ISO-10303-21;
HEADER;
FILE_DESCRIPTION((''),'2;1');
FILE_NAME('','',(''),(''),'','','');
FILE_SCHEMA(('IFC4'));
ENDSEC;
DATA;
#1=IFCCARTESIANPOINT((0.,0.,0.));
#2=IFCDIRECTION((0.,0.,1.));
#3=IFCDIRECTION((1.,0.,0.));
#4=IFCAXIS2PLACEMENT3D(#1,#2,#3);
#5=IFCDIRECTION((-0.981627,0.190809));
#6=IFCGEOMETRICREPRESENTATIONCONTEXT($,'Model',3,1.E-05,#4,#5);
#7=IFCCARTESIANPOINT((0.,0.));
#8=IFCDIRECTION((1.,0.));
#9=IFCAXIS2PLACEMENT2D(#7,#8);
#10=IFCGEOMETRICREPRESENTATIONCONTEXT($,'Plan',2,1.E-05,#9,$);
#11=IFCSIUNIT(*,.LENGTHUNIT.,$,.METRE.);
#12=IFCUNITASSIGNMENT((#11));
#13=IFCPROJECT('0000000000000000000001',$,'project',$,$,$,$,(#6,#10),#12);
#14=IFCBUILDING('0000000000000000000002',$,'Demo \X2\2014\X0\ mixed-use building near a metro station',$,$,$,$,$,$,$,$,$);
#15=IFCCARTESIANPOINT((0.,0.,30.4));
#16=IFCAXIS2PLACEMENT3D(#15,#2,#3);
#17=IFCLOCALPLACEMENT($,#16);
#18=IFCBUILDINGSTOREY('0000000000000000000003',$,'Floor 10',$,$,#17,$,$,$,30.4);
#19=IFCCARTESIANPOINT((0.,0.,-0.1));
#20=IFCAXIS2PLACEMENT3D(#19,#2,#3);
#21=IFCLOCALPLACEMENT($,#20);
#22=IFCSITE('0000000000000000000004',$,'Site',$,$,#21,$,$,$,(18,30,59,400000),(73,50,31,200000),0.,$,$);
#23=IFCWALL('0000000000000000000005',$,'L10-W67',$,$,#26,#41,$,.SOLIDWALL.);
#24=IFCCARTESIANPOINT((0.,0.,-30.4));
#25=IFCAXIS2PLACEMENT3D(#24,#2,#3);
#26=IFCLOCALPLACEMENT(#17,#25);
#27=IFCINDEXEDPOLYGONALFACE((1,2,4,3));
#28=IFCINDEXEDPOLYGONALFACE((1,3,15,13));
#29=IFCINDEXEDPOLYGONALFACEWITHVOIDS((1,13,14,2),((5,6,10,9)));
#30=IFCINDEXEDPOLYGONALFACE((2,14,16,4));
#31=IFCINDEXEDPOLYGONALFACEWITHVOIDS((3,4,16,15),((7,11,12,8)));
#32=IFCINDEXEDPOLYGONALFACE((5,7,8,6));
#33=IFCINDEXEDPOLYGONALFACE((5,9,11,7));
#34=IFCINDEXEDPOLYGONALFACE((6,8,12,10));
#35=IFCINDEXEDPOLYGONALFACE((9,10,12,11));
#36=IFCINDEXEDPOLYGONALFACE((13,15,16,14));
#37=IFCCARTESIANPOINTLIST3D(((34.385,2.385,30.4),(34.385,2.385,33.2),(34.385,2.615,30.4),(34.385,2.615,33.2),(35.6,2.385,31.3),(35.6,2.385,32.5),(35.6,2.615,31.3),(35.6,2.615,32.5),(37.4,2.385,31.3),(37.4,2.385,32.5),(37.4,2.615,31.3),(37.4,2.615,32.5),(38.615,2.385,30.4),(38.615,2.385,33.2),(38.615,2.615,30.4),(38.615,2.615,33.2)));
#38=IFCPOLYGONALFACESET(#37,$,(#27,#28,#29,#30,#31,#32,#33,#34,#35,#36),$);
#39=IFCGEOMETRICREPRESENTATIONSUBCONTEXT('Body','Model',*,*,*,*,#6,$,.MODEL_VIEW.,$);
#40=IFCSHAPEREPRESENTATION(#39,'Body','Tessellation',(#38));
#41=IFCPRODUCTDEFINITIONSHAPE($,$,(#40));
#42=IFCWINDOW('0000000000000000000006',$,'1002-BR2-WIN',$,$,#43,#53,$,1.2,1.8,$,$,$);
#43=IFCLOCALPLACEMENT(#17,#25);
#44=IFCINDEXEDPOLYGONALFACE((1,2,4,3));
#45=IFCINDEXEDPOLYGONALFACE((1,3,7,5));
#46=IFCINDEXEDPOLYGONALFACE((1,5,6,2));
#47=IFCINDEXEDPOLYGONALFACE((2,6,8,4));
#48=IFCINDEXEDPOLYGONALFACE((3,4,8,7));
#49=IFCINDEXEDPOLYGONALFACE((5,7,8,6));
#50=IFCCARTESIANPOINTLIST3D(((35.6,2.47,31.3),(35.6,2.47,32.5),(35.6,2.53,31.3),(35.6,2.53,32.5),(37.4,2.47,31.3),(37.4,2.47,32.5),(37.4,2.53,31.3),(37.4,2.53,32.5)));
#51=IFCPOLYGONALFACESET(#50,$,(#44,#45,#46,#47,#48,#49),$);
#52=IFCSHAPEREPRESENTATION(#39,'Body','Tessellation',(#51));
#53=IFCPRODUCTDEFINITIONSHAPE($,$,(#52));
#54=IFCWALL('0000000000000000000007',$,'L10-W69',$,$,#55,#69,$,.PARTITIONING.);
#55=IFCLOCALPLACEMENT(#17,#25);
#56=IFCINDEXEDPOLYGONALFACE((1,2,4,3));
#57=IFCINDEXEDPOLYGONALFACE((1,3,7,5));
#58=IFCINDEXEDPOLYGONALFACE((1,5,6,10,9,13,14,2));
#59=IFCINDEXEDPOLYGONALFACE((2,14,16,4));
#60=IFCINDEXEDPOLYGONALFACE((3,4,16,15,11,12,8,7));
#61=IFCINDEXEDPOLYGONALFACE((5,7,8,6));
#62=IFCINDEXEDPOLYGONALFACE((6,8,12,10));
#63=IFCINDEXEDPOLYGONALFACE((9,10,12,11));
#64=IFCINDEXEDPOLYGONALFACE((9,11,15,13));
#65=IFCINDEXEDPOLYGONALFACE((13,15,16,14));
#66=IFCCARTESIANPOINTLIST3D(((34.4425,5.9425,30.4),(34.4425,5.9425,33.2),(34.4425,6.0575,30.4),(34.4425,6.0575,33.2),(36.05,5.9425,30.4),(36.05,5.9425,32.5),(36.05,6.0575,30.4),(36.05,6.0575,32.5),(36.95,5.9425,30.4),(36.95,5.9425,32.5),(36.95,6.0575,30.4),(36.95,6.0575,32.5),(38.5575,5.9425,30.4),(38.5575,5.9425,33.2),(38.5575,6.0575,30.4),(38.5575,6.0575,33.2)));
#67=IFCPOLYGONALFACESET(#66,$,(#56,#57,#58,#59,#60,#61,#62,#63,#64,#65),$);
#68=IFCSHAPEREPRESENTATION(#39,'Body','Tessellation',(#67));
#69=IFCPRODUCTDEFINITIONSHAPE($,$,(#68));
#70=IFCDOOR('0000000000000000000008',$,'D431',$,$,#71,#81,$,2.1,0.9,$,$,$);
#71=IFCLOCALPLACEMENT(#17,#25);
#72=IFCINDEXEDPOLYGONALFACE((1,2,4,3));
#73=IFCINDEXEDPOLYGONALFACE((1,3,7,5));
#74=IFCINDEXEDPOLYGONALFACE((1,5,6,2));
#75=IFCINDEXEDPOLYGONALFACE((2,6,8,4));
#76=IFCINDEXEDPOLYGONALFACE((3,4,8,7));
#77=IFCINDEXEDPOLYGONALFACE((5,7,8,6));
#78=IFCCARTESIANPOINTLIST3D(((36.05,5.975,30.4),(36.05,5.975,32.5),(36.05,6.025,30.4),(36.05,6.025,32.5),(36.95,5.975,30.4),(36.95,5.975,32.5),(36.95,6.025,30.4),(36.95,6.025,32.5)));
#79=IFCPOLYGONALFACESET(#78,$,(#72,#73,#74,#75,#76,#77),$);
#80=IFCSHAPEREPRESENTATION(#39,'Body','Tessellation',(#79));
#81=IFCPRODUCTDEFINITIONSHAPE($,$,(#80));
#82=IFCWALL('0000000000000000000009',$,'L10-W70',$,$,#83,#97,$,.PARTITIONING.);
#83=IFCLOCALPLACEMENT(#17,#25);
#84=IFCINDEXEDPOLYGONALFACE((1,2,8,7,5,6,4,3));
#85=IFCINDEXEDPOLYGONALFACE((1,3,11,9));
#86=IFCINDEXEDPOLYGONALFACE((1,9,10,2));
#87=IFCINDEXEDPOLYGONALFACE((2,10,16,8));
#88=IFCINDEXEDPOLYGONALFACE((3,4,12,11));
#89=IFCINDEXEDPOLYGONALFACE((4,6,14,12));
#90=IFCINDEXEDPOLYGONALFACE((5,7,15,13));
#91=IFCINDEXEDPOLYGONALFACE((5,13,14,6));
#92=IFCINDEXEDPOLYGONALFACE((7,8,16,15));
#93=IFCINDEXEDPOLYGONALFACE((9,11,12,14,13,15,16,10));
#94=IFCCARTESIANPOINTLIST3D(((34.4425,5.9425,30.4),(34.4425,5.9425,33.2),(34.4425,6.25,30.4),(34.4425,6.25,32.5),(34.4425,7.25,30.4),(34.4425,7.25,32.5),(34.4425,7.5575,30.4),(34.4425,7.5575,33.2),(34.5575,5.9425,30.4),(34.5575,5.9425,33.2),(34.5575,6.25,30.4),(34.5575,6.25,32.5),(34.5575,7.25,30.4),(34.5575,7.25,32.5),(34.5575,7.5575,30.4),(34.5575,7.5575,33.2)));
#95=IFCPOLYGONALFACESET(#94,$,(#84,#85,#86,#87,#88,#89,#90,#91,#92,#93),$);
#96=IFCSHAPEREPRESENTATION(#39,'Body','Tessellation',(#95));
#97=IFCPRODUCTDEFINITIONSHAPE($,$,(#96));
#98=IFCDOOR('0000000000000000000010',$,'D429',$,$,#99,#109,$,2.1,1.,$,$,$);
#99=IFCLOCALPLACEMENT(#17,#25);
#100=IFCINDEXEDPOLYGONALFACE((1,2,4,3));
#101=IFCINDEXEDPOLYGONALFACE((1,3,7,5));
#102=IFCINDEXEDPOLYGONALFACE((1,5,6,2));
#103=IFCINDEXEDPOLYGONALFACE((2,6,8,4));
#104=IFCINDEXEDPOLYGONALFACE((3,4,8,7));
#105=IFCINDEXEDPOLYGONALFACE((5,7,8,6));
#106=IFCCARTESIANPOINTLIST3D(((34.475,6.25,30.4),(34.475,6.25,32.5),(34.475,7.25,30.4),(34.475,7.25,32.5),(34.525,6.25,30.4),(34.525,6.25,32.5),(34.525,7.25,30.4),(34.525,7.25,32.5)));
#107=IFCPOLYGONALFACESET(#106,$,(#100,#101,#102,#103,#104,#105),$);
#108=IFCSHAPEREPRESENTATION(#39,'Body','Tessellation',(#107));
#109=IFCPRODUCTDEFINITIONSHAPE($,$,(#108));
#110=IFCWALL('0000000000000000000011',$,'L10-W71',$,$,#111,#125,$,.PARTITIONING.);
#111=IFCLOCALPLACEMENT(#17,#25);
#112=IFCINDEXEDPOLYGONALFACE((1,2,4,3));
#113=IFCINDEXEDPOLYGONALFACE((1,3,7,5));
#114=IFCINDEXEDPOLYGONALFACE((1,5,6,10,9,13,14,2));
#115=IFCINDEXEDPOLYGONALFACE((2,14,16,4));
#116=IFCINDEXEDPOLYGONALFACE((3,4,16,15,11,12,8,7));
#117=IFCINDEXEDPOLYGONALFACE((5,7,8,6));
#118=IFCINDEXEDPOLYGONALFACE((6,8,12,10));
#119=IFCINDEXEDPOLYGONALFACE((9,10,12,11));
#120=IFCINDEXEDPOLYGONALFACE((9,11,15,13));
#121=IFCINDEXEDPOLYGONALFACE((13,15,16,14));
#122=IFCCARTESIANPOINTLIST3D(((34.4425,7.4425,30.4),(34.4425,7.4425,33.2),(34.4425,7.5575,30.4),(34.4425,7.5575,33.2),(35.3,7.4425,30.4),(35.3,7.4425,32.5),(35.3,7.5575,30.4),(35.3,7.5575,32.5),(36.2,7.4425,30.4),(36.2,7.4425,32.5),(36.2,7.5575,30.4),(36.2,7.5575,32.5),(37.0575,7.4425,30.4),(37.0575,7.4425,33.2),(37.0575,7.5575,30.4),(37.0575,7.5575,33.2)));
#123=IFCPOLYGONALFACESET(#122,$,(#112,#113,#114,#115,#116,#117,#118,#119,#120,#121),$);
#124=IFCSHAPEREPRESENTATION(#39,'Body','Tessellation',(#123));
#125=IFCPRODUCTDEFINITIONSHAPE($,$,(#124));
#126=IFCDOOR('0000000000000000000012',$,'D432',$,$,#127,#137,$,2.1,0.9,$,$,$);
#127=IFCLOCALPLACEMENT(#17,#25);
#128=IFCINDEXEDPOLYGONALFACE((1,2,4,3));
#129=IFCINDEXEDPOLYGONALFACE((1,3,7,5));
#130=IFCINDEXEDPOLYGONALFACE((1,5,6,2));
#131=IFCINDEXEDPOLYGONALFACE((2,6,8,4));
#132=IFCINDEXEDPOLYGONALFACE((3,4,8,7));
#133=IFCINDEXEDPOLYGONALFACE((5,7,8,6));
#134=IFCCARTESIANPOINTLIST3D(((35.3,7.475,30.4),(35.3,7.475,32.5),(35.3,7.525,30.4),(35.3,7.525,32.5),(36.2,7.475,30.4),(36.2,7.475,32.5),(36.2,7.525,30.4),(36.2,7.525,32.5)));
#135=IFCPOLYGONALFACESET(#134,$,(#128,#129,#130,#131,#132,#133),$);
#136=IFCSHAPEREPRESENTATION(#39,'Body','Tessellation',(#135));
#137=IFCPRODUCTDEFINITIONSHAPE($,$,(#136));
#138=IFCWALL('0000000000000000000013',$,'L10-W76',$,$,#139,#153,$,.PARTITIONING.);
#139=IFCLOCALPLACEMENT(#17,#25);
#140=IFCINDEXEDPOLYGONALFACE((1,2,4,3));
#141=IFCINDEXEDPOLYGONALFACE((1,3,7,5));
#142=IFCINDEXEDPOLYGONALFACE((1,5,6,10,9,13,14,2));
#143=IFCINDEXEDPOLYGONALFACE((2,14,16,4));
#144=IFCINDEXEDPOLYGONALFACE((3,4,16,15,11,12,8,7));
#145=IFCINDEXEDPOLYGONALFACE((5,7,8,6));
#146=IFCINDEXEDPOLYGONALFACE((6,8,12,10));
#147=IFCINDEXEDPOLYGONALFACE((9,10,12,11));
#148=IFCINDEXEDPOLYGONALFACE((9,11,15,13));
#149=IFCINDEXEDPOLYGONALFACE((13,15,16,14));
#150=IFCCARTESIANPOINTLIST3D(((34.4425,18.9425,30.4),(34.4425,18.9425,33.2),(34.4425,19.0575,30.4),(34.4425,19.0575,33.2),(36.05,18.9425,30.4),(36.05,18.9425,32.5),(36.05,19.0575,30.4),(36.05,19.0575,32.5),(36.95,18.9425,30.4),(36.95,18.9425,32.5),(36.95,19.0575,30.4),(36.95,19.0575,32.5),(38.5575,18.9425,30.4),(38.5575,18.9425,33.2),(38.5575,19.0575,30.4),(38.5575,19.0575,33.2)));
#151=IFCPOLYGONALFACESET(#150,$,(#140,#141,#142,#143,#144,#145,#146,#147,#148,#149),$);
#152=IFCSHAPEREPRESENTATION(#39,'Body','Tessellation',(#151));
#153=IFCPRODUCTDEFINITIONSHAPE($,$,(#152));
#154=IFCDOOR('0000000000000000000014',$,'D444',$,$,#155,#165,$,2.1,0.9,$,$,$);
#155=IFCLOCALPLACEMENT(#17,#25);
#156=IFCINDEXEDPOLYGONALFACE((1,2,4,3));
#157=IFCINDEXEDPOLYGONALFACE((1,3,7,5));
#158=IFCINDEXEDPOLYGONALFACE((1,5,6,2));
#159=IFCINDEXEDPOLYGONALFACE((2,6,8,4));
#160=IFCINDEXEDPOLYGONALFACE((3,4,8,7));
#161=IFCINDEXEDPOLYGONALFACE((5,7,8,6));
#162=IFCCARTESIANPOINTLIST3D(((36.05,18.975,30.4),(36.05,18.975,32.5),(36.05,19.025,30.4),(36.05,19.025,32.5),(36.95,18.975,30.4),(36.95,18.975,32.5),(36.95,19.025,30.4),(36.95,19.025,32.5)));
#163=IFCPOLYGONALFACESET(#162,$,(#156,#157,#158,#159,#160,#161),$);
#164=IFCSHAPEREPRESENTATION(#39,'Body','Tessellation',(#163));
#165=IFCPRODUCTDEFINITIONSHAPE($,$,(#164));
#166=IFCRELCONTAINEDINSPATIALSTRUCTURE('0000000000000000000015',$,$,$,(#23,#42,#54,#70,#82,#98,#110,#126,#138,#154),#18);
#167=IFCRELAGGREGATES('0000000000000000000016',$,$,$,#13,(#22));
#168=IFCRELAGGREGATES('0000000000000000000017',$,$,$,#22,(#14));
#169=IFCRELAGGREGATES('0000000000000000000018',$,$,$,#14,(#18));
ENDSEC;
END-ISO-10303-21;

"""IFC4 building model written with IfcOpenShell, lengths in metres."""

from ifc_helpers import new_model, si_unit, direction, frame, origin_with_axes, origin_2d_with_axis, place, context, subcontext, project, spatial, line, indexed_curve, outline, extrude, element, fill, save


model = new_model("IFC4")

# Units and contexts
model_context = context("Model", 3, precision=1e-05, world=origin_with_axes(), true_north=direction((-0.981627, 0.190809)))
plan_context = context("Plan", 2, precision=1e-05, world=origin_2d_with_axis())
body_context = subcontext(model_context, "Body", "Model", "MODEL_VIEW")
ifc_project = project(units=[si_unit("LENGTHUNIT", "METRE")], contexts=[model_context, plan_context])

# Site, building, storey
site_placement = place(None, frame((0.0, 0.0, -0.1), z_axis=(0.0, 0.0, 1.0), x_axis=(1.0, 0.0, 0.0)))
site = spatial("IfcSite", under=ifc_project, at=site_placement, Name="Site", RefLatitude=(18, 30, 59, 400000), RefLongitude=(73, 50, 31, 200000), RefElevation=0.0)
building = spatial("IfcBuilding", under=site, Name="Demo — mixed-use building near a metro station")
storey_placement = place(None, frame((0.0, 0.0, 30.4), z_axis=(0.0, 0.0, 1.0), x_axis=(1.0, 0.0, 0.0)))
storey = spatial("IfcBuildingStorey", under=building, at=storey_placement, Name="Floor 10", Elevation=30.4)

# Wall, opening, window
wall_1_placement = place(storey_placement, frame((0.0, 0.0, -30.4), z_axis=(0.0, 0.0, 1.0), x_axis=(1.0, 0.0, 0.0)))
wall_1 = element("IfcWall", 1, at=wall_1_placement, inside=storey, Name="L10-W67", PredefinedType="SOLIDWALL", context=body_context, shape_type="SweptSolid", body=[
    extrude(outline(indexed_curve([(34.385, 2.615), (38.615, 2.615), (38.615, 2.385), (34.385, 2.385)], segments=[line(1, 2, 3, 4, 1)])), frame((0.0, 0.0, 30.4), z_axis=(0.0, 0.0, 1.0), x_axis=(1.0, 0.0, 0.0)), (0.0, 0.0, 1.0), 2.8),
])
opening_1_placement = place(wall_1_placement, origin_with_axes())
opening_1 = element("IfcOpeningElement", 2, at=opening_1_placement, cuts=wall_1, context=body_context, shape_type="SweptSolid", body=[
    extrude(outline(indexed_curve([(35.6, 2.665), (37.4, 2.665), (37.4, 2.335), (35.6, 2.335)], segments=[line(1, 2, 3, 4, 1)])), frame((0.0, 0.0, 31.3), z_axis=(0.0, 0.0, 1.0), x_axis=(1.0, 0.0, 0.0)), (0.0, 0.0, 1.0), 1.2),
])
window_placement = place(storey_placement, frame((0.0, 0.0, -30.4), z_axis=(0.0, 0.0, 1.0), x_axis=(1.0, 0.0, 0.0)))
window = element("IfcWindow", 3, at=window_placement, inside=storey, Name="1002-BR2-WIN", OverallHeight=1.2, OverallWidth=1.8, context=body_context, shape_type="SweptSolid", body=[
    extrude(outline(indexed_curve([(35.6, 2.53), (37.4, 2.53), (37.4, 2.47), (35.6, 2.47)], segments=[line(1, 2, 3, 4, 1)])), frame((0.0, 0.0, 31.3), z_axis=(0.0, 0.0, 1.0), x_axis=(1.0, 0.0, 0.0)), (0.0, 0.0, 1.0), 1.2),
])
fill(opening_1, window)

# Walls, openings, doors
wall_2_placement = place(storey_placement, frame((0.0, 0.0, -30.4), z_axis=(0.0, 0.0, 1.0), x_axis=(1.0, 0.0, 0.0)))
wall_2 = element("IfcWall", 4, at=wall_2_placement, inside=storey, Name="L10-W69", PredefinedType="PARTITIONING", context=body_context, shape_type="SweptSolid", body=[
    extrude(outline(indexed_curve([(38.5575, 5.9425), (34.4425, 5.9425), (34.4425, 6.0575), (38.5575, 6.0575)], segments=[line(1, 2, 3, 4, 1)])), frame((0.0, 0.0, 30.4), z_axis=(0.0, 0.0, 1.0), x_axis=(1.0, 0.0, 0.0)), (0.0, 0.0, 1.0), 2.8),
])
opening_2_placement = place(wall_2_placement, origin_with_axes())
opening_2 = element("IfcOpeningElement", 5, at=opening_2_placement, cuts=wall_2, context=body_context, shape_type="SweptSolid", body=[
    extrude(outline(indexed_curve([(36.95, 5.8925), (36.05, 5.8925), (36.05, 6.1075), (36.95, 6.1075)], segments=[line(1, 2, 3, 4, 1)])), frame((0.0, 0.0, 30.4), z_axis=(0.0, 0.0, 1.0), x_axis=(1.0, 0.0, 0.0)), (0.0, 0.0, 1.0), 2.1),
])
door_1_placement = place(storey_placement, frame((0.0, 0.0, -30.4), z_axis=(0.0, 0.0, 1.0), x_axis=(1.0, 0.0, 0.0)))
door_1 = element("IfcDoor", 6, at=door_1_placement, inside=storey, Name="D431", OverallHeight=2.1, OverallWidth=0.9, context=body_context, shape_type="SweptSolid", body=[
    extrude(outline(indexed_curve([(36.95, 5.975), (36.05, 5.975), (36.05, 6.025), (36.95, 6.025)], segments=[line(1, 2, 3, 4, 1)])), frame((0.0, 0.0, 30.4), z_axis=(0.0, 0.0, 1.0), x_axis=(1.0, 0.0, 0.0)), (0.0, 0.0, 1.0), 2.1),
])
fill(opening_2, door_1)
wall_3_placement = place(storey_placement, frame((0.0, 0.0, -30.4), z_axis=(0.0, 0.0, 1.0), x_axis=(1.0, 0.0, 0.0)))
wall_3 = element("IfcWall", 7, at=wall_3_placement, inside=storey, Name="L10-W70", PredefinedType="PARTITIONING", context=body_context, shape_type="SweptSolid", body=[
    extrude(outline(indexed_curve([(34.4425, 5.9425), (34.4425, 7.5575), (34.5575, 7.5575), (34.5575, 5.9425)], segments=[line(1, 2, 3, 4, 1)])), frame((0.0, 0.0, 30.4), z_axis=(0.0, 0.0, 1.0), x_axis=(1.0, 0.0, 0.0)), (0.0, 0.0, 1.0), 2.8),
])
opening_3_placement = place(wall_3_placement, origin_with_axes())
opening_3 = element("IfcOpeningElement", 8, at=opening_3_placement, cuts=wall_3, context=body_context, shape_type="SweptSolid", body=[
    extrude(outline(indexed_curve([(34.3925, 6.25), (34.3925, 7.25), (34.6075, 7.25), (34.6075, 6.25)], segments=[line(1, 2, 3, 4, 1)])), frame((0.0, 0.0, 30.4), z_axis=(0.0, 0.0, 1.0), x_axis=(1.0, 0.0, 0.0)), (0.0, 0.0, 1.0), 2.1),
])
door_2_placement = place(storey_placement, frame((0.0, 0.0, -30.4), z_axis=(0.0, 0.0, 1.0), x_axis=(1.0, 0.0, 0.0)))
door_2 = element("IfcDoor", 9, at=door_2_placement, inside=storey, Name="D429", OverallHeight=2.1, OverallWidth=1.0, context=body_context, shape_type="SweptSolid", body=[
    extrude(outline(indexed_curve([(34.475, 6.25), (34.475, 7.25), (34.525, 7.25), (34.525, 6.25)], segments=[line(1, 2, 3, 4, 1)])), frame((0.0, 0.0, 30.4), z_axis=(0.0, 0.0, 1.0), x_axis=(1.0, 0.0, 0.0)), (0.0, 0.0, 1.0), 2.1),
])
fill(opening_3, door_2)
wall_4_placement = place(storey_placement, frame((0.0, 0.0, -30.4), z_axis=(0.0, 0.0, 1.0), x_axis=(1.0, 0.0, 0.0)))
wall_4 = element("IfcWall", 10, at=wall_4_placement, inside=storey, Name="L10-W71", PredefinedType="PARTITIONING", context=body_context, shape_type="SweptSolid", body=[
    extrude(outline(indexed_curve([(37.0575, 7.4425), (34.4425, 7.4425), (34.4425, 7.5575), (37.0575, 7.5575)], segments=[line(1, 2, 3, 4, 1)])), frame((0.0, 0.0, 30.4), z_axis=(0.0, 0.0, 1.0), x_axis=(1.0, 0.0, 0.0)), (0.0, 0.0, 1.0), 2.8),
])
opening_4_placement = place(wall_4_placement, origin_with_axes())
opening_4 = element("IfcOpeningElement", 11, at=opening_4_placement, cuts=wall_4, context=body_context, shape_type="SweptSolid", body=[
    extrude(outline(indexed_curve([(36.2, 7.3925), (35.3, 7.3925), (35.3, 7.6075), (36.2, 7.6075)], segments=[line(1, 2, 3, 4, 1)])), frame((0.0, 0.0, 30.4), z_axis=(0.0, 0.0, 1.0), x_axis=(1.0, 0.0, 0.0)), (0.0, 0.0, 1.0), 2.1),
])
door_3_placement = place(storey_placement, frame((0.0, 0.0, -30.4), z_axis=(0.0, 0.0, 1.0), x_axis=(1.0, 0.0, 0.0)))
door_3 = element("IfcDoor", 12, at=door_3_placement, inside=storey, Name="D432", OverallHeight=2.1, OverallWidth=0.9, context=body_context, shape_type="SweptSolid", body=[
    extrude(outline(indexed_curve([(36.2, 7.475), (35.3, 7.475), (35.3, 7.525), (36.2, 7.525)], segments=[line(1, 2, 3, 4, 1)])), frame((0.0, 0.0, 30.4), z_axis=(0.0, 0.0, 1.0), x_axis=(1.0, 0.0, 0.0)), (0.0, 0.0, 1.0), 2.1),
])
fill(opening_4, door_3)

# Wall, opening, door
wall_5_placement = place(storey_placement, frame((0.0, 0.0, -30.4), z_axis=(0.0, 0.0, 1.0), x_axis=(1.0, 0.0, 0.0)))
wall_5 = element("IfcWall", 13, at=wall_5_placement, inside=storey, Name="L10-W76", PredefinedType="PARTITIONING", context=body_context, shape_type="SweptSolid", body=[
    extrude(outline(indexed_curve([(38.5575, 18.9425), (34.4425, 18.9425), (34.4425, 19.0575), (38.5575, 19.0575)], segments=[line(1, 2, 3, 4, 1)])), frame((0.0, 0.0, 30.4), z_axis=(0.0, 0.0, 1.0), x_axis=(1.0, 0.0, 0.0)), (0.0, 0.0, 1.0), 2.8),
])
opening_5_placement = place(wall_5_placement, origin_with_axes())
opening_5 = element("IfcOpeningElement", 14, at=opening_5_placement, cuts=wall_5, context=body_context, shape_type="SweptSolid", body=[
    extrude(outline(indexed_curve([(36.95, 18.8925), (36.05, 18.8925), (36.05, 19.1075), (36.95, 19.1075)], segments=[line(1, 2, 3, 4, 1)])), frame((0.0, 0.0, 30.4), z_axis=(0.0, 0.0, 1.0), x_axis=(1.0, 0.0, 0.0)), (0.0, 0.0, 1.0), 2.1),
])
door_4_placement = place(storey_placement, frame((0.0, 0.0, -30.4), z_axis=(0.0, 0.0, 1.0), x_axis=(1.0, 0.0, 0.0)))
door_4 = element("IfcDoor", 15, at=door_4_placement, inside=storey, Name="D444", OverallHeight=2.1, OverallWidth=0.9, context=body_context, shape_type="SweptSolid", body=[
    extrude(outline(indexed_curve([(36.95, 18.975), (36.05, 18.975), (36.05, 19.025), (36.95, 19.025)], segments=[line(1, 2, 3, 4, 1)])), frame((0.0, 0.0, 30.4), z_axis=(0.0, 0.0, 1.0), x_axis=(1.0, 0.0, 0.0)), (0.0, 0.0, 1.0), 2.1),
])
fill(opening_5, door_4)

save(model, "model.ifc")
